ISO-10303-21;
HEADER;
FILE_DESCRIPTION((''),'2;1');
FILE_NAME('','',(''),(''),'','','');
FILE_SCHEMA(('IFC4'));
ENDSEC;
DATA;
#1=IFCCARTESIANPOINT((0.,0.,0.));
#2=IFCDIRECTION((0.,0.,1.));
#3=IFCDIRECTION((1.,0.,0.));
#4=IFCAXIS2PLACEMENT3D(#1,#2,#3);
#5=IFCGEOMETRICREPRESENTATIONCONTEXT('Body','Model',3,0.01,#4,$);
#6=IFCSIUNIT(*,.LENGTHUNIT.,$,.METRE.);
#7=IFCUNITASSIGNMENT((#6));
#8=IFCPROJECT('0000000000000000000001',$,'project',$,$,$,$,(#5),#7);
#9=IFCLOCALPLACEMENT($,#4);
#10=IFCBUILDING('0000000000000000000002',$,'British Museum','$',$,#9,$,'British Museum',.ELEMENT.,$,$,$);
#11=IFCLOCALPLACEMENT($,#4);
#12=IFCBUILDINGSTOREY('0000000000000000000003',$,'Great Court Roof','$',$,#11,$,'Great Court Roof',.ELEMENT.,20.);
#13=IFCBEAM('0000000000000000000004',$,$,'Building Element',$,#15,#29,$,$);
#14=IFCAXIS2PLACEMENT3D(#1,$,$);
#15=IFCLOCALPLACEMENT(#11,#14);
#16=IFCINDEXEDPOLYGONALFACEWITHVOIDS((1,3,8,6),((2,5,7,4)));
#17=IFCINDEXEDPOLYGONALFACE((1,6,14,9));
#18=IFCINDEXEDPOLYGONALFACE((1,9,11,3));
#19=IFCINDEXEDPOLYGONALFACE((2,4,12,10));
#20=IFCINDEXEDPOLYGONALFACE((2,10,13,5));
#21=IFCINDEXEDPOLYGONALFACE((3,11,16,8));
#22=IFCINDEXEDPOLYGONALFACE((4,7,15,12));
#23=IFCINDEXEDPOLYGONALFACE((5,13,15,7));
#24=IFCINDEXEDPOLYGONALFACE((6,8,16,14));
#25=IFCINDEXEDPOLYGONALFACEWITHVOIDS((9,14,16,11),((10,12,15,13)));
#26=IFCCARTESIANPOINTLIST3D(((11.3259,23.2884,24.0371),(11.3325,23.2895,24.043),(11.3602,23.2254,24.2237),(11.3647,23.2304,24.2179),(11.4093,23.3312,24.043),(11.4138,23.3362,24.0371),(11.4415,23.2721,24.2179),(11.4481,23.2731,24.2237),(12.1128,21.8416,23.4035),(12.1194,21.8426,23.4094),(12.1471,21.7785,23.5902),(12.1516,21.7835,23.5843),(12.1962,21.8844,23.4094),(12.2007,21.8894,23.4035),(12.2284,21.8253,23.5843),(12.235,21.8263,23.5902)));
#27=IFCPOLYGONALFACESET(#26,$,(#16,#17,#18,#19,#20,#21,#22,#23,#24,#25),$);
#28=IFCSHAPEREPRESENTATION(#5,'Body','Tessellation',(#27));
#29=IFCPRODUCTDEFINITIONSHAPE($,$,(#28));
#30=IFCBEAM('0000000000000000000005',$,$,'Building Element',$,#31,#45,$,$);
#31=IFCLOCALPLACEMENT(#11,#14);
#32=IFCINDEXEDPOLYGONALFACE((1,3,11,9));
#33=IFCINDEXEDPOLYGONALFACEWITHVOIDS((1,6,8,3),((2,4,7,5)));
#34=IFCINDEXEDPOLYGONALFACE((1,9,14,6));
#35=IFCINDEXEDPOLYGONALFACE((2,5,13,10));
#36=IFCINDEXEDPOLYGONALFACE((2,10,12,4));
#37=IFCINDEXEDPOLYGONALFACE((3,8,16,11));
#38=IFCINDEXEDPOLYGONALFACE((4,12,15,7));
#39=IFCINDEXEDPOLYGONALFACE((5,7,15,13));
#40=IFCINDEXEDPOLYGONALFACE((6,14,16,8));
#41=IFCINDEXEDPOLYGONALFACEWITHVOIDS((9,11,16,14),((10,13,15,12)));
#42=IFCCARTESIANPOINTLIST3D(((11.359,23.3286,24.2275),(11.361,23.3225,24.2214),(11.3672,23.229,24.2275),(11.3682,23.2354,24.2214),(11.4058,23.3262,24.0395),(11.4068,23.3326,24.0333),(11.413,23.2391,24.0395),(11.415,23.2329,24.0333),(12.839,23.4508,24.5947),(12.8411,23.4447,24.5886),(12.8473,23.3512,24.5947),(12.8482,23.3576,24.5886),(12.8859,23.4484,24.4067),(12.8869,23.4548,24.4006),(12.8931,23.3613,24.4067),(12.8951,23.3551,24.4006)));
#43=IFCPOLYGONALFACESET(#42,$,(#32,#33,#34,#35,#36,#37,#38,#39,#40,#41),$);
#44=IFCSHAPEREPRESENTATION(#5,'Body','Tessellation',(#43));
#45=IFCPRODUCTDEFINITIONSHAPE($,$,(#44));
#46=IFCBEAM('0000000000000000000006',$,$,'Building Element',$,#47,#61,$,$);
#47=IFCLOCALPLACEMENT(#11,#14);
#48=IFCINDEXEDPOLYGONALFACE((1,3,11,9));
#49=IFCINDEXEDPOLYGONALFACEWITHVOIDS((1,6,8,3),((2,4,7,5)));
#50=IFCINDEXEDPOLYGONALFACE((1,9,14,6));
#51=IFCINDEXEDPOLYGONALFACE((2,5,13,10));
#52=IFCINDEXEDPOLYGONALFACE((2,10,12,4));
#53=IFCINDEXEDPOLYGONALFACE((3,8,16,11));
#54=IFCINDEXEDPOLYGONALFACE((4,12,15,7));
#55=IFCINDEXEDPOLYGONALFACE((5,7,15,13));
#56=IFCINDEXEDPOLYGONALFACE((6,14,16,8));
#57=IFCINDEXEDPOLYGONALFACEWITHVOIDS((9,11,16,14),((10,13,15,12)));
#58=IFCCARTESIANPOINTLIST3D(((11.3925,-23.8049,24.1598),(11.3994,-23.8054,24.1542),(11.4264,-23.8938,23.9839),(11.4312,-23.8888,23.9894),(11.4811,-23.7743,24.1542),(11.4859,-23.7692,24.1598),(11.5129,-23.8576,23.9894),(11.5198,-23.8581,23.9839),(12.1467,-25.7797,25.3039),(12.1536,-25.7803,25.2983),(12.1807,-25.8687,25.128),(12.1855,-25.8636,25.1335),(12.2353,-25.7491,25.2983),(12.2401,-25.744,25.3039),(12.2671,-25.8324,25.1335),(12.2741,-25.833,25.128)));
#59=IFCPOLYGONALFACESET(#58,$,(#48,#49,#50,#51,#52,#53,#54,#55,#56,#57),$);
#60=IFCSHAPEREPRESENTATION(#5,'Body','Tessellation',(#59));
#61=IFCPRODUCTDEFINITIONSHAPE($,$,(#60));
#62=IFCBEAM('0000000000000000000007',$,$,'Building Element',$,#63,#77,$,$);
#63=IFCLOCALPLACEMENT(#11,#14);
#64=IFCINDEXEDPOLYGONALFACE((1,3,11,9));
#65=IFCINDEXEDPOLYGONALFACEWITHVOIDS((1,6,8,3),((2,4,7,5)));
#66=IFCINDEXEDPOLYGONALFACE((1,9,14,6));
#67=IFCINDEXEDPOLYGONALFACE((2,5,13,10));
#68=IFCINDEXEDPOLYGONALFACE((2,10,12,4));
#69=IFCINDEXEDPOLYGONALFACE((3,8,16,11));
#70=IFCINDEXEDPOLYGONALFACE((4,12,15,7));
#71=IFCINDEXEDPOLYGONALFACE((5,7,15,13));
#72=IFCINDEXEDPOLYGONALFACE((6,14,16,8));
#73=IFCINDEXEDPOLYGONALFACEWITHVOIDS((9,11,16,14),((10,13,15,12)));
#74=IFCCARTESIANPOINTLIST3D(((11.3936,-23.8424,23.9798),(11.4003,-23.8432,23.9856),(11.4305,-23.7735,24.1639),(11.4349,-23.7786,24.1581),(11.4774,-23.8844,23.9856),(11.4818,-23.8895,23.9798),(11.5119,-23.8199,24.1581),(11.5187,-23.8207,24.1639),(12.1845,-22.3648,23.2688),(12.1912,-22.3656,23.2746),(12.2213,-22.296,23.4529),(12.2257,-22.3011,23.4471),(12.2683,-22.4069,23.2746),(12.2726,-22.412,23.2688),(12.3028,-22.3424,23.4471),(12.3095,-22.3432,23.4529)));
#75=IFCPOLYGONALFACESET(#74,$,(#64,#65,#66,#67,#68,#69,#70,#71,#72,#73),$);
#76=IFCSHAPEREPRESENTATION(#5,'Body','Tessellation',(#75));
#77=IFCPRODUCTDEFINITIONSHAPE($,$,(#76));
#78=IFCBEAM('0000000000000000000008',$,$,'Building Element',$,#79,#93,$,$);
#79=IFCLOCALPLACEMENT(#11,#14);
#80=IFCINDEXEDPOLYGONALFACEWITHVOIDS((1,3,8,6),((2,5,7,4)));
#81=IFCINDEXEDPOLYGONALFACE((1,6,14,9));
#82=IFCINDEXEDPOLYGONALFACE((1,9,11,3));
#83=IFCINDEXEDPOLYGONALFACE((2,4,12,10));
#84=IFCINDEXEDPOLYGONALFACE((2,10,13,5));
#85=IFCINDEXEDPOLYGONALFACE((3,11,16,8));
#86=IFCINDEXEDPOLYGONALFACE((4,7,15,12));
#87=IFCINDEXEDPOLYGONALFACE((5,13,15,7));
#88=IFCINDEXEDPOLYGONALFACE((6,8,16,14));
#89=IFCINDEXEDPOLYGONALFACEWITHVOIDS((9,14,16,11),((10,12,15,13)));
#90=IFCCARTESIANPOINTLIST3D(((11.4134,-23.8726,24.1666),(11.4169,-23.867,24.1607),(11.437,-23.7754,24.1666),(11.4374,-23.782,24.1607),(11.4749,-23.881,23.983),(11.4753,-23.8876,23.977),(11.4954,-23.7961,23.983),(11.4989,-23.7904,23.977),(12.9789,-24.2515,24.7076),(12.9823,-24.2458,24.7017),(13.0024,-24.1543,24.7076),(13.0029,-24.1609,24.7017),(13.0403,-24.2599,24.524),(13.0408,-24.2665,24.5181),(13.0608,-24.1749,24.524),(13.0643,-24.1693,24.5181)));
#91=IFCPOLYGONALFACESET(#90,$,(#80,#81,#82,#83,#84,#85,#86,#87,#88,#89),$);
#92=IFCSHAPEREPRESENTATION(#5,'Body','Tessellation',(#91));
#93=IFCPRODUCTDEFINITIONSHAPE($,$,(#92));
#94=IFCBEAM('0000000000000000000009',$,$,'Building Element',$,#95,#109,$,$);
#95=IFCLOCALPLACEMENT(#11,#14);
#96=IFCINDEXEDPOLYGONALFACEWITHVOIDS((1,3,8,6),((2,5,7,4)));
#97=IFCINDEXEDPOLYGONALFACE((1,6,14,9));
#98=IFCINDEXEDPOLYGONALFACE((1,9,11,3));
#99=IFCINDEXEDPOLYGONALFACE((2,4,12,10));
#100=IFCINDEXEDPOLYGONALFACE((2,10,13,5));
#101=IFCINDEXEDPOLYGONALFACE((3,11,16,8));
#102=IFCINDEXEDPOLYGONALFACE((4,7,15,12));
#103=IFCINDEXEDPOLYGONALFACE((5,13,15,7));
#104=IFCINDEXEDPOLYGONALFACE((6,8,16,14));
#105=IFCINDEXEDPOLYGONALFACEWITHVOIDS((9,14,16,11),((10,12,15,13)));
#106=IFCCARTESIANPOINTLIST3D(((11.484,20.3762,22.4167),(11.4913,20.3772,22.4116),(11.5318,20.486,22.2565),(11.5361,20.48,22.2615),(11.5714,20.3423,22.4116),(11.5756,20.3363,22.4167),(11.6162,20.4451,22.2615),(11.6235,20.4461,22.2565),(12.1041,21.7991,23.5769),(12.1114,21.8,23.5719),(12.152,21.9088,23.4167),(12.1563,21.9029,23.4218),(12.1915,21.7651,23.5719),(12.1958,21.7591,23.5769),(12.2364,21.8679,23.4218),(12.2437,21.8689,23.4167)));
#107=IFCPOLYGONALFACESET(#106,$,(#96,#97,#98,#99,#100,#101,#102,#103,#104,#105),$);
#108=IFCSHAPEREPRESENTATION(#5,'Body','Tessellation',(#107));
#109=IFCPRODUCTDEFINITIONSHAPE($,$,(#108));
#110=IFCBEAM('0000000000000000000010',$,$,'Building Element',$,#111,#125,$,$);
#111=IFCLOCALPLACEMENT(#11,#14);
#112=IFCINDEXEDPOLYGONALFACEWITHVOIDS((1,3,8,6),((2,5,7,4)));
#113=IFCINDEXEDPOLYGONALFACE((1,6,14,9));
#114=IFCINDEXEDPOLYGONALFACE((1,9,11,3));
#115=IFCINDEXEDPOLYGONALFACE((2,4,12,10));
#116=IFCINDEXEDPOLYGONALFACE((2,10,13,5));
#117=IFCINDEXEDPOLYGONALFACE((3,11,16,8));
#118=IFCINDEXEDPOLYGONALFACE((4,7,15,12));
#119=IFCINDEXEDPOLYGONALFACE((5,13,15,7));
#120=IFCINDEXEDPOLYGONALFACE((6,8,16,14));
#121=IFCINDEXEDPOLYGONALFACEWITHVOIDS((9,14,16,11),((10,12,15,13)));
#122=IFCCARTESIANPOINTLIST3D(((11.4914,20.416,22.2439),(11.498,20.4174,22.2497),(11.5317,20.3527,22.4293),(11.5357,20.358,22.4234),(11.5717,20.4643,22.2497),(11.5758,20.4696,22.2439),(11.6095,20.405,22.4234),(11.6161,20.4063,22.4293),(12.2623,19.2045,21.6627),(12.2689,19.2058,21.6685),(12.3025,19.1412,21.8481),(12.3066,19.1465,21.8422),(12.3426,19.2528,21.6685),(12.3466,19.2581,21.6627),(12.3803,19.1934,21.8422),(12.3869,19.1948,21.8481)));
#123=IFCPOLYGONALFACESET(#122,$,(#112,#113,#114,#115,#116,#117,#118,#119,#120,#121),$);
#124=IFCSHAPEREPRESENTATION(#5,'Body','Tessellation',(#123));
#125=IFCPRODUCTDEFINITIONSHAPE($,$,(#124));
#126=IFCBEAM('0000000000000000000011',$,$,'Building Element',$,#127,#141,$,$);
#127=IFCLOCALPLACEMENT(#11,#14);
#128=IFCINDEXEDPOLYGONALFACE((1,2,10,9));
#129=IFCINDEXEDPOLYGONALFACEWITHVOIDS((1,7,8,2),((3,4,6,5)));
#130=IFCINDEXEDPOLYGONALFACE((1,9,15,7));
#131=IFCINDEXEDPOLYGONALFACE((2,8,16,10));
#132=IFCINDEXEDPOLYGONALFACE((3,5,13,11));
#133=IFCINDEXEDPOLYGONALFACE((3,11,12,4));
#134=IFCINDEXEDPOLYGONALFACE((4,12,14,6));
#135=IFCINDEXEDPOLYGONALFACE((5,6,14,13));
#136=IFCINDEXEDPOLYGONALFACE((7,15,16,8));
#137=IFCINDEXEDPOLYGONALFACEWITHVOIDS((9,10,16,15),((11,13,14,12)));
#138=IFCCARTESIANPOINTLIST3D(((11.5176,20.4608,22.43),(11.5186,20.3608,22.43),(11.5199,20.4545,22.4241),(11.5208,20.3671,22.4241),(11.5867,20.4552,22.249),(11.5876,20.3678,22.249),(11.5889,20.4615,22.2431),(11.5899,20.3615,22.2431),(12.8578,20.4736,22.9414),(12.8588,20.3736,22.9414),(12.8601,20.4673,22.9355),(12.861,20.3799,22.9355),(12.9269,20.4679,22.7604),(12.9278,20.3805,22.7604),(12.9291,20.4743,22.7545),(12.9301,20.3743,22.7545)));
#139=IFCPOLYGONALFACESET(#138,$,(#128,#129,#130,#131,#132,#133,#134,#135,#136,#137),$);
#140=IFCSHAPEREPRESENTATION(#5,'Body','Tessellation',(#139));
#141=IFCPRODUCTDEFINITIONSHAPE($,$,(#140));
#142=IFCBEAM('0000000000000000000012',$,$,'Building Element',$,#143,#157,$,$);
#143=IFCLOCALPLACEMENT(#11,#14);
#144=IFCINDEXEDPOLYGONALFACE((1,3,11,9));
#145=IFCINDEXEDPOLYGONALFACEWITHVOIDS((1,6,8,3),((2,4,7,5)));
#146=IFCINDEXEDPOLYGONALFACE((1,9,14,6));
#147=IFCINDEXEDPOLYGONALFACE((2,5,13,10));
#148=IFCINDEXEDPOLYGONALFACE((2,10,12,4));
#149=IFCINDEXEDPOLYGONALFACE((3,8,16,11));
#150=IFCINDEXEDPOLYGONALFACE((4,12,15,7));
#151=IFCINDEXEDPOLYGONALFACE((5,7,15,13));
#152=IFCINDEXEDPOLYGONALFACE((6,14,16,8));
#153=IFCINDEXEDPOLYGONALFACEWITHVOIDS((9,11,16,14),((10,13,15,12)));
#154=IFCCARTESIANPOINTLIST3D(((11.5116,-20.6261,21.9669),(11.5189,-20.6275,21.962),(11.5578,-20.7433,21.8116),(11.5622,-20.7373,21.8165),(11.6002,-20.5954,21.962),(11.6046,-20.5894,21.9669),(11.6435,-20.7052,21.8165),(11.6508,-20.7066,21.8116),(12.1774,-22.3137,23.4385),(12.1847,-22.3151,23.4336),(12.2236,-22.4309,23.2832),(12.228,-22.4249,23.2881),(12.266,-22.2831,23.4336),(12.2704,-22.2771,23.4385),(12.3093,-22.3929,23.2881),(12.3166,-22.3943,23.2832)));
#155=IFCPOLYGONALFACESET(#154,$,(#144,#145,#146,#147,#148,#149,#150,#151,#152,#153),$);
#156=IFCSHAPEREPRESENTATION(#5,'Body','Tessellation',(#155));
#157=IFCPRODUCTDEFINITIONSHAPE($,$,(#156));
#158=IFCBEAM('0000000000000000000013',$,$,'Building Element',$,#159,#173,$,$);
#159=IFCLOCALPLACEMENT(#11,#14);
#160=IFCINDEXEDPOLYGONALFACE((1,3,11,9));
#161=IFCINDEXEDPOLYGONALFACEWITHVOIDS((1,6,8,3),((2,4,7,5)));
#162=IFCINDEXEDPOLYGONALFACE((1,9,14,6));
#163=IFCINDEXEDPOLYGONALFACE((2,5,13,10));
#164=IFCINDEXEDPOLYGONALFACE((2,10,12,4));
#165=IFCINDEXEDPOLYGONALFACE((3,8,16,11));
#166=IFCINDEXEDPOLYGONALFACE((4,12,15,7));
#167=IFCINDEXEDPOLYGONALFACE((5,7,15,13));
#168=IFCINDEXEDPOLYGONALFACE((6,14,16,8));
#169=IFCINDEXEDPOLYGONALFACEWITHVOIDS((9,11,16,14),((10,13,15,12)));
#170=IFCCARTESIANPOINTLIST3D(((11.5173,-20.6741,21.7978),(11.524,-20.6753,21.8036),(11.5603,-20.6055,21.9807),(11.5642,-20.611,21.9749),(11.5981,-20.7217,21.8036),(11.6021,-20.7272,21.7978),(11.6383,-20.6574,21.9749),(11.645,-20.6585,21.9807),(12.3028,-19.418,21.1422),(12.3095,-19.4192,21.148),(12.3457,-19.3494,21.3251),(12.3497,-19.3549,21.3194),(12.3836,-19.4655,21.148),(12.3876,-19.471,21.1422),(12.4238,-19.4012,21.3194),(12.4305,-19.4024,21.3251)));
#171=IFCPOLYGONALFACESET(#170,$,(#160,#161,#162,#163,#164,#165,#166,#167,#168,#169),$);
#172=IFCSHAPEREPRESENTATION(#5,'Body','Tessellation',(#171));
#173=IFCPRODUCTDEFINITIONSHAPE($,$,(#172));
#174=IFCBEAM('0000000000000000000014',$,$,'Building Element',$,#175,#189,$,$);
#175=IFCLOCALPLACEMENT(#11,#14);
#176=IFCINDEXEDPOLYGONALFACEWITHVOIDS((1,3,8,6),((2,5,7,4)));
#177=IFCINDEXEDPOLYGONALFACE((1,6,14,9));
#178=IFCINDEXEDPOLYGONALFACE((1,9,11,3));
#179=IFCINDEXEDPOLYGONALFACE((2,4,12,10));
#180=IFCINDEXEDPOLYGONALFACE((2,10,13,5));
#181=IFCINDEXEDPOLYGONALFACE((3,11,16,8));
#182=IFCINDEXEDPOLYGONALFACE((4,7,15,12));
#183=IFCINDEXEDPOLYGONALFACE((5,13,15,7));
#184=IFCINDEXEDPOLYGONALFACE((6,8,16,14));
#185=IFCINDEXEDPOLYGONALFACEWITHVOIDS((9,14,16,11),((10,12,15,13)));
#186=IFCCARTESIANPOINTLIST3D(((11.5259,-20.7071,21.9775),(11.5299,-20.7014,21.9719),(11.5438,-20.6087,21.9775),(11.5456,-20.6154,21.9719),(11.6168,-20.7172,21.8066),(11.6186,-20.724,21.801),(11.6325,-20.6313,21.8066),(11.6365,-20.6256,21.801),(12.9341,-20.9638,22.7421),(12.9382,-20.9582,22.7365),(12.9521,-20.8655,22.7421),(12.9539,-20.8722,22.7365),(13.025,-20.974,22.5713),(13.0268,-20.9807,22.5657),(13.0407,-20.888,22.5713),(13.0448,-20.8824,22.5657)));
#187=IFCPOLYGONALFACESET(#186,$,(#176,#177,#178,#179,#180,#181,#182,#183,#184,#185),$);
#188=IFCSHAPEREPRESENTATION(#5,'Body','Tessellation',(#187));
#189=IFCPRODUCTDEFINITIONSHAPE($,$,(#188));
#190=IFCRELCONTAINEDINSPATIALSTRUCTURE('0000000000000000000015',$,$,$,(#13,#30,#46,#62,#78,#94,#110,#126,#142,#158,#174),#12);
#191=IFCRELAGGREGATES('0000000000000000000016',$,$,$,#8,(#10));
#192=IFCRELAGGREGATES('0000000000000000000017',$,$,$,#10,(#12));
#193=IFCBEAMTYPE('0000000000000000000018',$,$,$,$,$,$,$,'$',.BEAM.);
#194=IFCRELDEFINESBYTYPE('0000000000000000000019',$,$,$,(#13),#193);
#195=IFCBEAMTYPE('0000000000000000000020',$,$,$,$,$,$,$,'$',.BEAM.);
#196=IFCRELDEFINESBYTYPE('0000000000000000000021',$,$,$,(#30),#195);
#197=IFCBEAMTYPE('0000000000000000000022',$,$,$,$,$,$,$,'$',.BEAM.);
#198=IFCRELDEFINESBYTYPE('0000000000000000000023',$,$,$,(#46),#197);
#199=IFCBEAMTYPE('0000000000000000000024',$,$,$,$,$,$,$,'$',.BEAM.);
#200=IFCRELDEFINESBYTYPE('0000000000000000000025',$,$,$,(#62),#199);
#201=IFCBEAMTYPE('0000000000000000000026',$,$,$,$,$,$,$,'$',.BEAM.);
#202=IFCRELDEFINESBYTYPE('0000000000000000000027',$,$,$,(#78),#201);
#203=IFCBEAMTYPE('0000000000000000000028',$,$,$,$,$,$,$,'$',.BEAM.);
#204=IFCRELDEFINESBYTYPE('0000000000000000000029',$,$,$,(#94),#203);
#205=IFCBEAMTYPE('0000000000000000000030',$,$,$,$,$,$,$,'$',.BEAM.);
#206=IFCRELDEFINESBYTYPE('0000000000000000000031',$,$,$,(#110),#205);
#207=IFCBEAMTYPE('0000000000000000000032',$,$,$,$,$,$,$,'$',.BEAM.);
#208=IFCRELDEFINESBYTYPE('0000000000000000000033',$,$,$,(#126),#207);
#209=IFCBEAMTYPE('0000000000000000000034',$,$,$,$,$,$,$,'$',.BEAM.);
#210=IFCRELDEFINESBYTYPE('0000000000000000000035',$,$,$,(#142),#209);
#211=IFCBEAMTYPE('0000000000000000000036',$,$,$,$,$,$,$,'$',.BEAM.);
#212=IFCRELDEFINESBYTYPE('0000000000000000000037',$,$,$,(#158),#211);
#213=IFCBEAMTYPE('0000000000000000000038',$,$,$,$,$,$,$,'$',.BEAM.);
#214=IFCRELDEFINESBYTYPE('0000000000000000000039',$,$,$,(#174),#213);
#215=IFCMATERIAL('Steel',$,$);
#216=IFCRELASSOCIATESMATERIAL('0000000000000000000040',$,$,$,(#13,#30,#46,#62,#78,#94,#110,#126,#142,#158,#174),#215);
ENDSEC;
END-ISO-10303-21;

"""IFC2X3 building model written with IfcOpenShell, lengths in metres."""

from ifc_helpers import new_model, si_unit, frame, origin_with_axes, origin_2d, place, context, project, spatial, hollow_rectangle, extrude, material, type_object, element, save


model = new_model("IFC2X3")

# Units and contexts
model_context = context("Model", 3, precision=0.01, world=origin_with_axes(), identifier="Body")
ifc_project = project(units=[si_unit("LENGTHUNIT", "METRE")], contexts=[model_context])

# Building, storey
building_placement = place(None, origin_with_axes())
building = spatial("IfcBuilding", under=ifc_project, at=building_placement, Name="British Museum", Description="$", LongName="British Museum", CompositionType="ELEMENT")
storey_placement = place(None, origin_with_axes())
storey = spatial("IfcBuildingStorey", under=building, at=storey_placement, Name="Great Court Roof", Description="$", LongName="Great Court Roof", CompositionType="ELEMENT", Elevation=20.0)

# Beams
ifc_material = material(Name="Steel")
beam_type_1 = type_object("IfcBeamType", ElementType="$", PredefinedType="BEAM")
beam_1_placement = place(None, origin_with_axes())
element("IfcBeam", 1, at=beam_1_placement, inside=storey, type_object=beam_type_1, material=ifc_material, Description="Building Element", context=model_context, shape_type="SweptSolid", body=[
    extrude(hollow_rectangle(XDim=0.1, YDim=0.2, WallThickness=0.0063, InnerFilletRadius=-0.0063, OuterFilletRadius=0.0, at=origin_2d()), frame((11.387, 23.2808, 24.1304), z_axis=(0.445928, -0.819903, -0.359038), x_axis=(0.878477, 0.477785, 0.0)), (0.0, 0.0, 1.0), 1.7646),
])
beam_type_2 = type_object("IfcBeamType", ElementType="$", PredefinedType="BEAM")
beam_2_placement = place(None, origin_with_axes())
element("IfcBeam", 2, at=beam_2_placement, inside=storey, type_object=beam_type_2, material=ifc_material, Description="Building Element", context=model_context, shape_type="SweptSolid", body=[
    extrude(hollow_rectangle(XDim=0.1, YDim=0.2, WallThickness=0.0063, InnerFilletRadius=-0.0063, OuterFilletRadius=0.0, at=origin_2d()), frame((11.387, 23.2808, 24.1304), z_axis=(0.967466, 0.07987, 0.240061), x_axis=(-0.082276, 0.99661, 0.0)), (0.0, 0.0, 1.0), 1.5298),
])
beam_type_3 = type_object("IfcBeamType", ElementType="$", PredefinedType="BEAM")
beam_3_placement = place(None, origin_with_axes())
element("IfcBeam", 3, at=beam_3_placement, inside=storey, type_object=beam_type_3, material=ifc_material, Description="Building Element", context=model_context, shape_type="SweptSolid", body=[
    extrude(hollow_rectangle(XDim=0.1, YDim=0.2, WallThickness=0.0063, InnerFilletRadius=-0.0063, OuterFilletRadius=0.0, at=origin_2d()), frame((11.4561, -23.8315, 24.0718), z_axis=(0.31378, -0.821581, 0.47597), x_axis=(0.934186, 0.356787, 0.0)), (0.0, 0.0, 1.0), 2.4037),
])
beam_type_4 = type_object("IfcBeamType", ElementType="$", PredefinedType="BEAM")
beam_4_placement = place(None, origin_with_axes())
element("IfcBeam", 4, at=beam_4_placement, inside=storey, type_object=beam_type_4, material=ifc_material, Description="Building Element", context=model_context, shape_type="SweptSolid", body=[
    extrude(hollow_rectangle(XDim=0.1, YDim=0.2, WallThickness=0.0063, InnerFilletRadius=-0.0063, OuterFilletRadius=0.0, at=origin_2d()), frame((11.4561, -23.8315, 24.0718), z_axis=(0.43443, 0.811623, -0.390562), x_axis=(-0.881646, 0.471911, 0.0)), (0.0, 0.0, 1.0), 1.8204),
])
beam_type_5 = type_object("IfcBeamType", ElementType="$", PredefinedType="BEAM")
beam_5_placement = place(None, origin_with_axes())
element("IfcBeam", 5, at=beam_5_placement, inside=storey, type_object=beam_type_5, material=ifc_material, Description="Building Element", context=model_context, shape_type="SweptSolid", body=[
    extrude(hollow_rectangle(XDim=0.1, YDim=0.2, WallThickness=0.0063, InnerFilletRadius=-0.0063, OuterFilletRadius=0.0, at=origin_2d()), frame((11.4561, -23.8315, 24.0718), z_axis=(0.921349, -0.222991, 0.318418), x_axis=(0.235235, 0.971938, 0.0)), (0.0, 0.0, 1.0), 1.6991),
])
beam_type_6 = type_object("IfcBeamType", ElementType="$", PredefinedType="BEAM")
beam_6_placement = place(None, origin_with_axes())
element("IfcBeam", 6, at=beam_6_placement, inside=storey, type_object=beam_type_6, material=ifc_material, Description="Building Element", context=model_context, shape_type="SweptSolid", body=[
    extrude(hollow_rectangle(XDim=0.1, YDim=0.2, WallThickness=0.0063, InnerFilletRadius=-0.0063, OuterFilletRadius=0.0, at=origin_2d()), frame((11.5537, 20.4112, 22.3366), z_axis=(0.320027, 0.734228, 0.598742), x_axis=(-0.916706, 0.399563, 0.0)), (0.0, 0.0, 1.0), 1.9378),
])
beam_type_7 = type_object("IfcBeamType", ElementType="$", PredefinedType="BEAM")
beam_7_placement = place(None, origin_with_axes())
element("IfcBeam", 7, at=beam_7_placement, inside=storey, type_object=beam_type_7, material=ifc_material, Description="Building Element", context=model_context, shape_type="SweptSolid", body=[
    extrude(hollow_rectangle(XDim=0.1, YDim=0.2, WallThickness=0.0063, InnerFilletRadius=-0.0063, OuterFilletRadius=0.0, at=origin_2d()), frame((11.5537, 20.4112, 22.3366), z_axis=(0.497612, -0.782064, -0.375178), x_axis=(0.843693, 0.536825, 0.0)), (0.0, 0.0, 1.0), 1.5491),
])
beam_type_8 = type_object("IfcBeamType", ElementType="$", PredefinedType="BEAM")
beam_8_placement = place(None, origin_with_axes())
element("IfcBeam", 8, at=beam_8_placement, inside=storey, type_object=beam_type_8, material=ifc_material, Description="Building Element", context=model_context, shape_type="SweptSolid", body=[
    extrude(hollow_rectangle(XDim=0.1, YDim=0.2, WallThickness=0.0063, InnerFilletRadius=-0.0063, OuterFilletRadius=0.0, at=origin_2d()), frame((11.5537, 20.4112, 22.3366), z_axis=(0.934258, 0.008904, 0.356487), x_axis=(-0.00953, 0.999955, 0.0)), (0.0, 0.0, 1.0), 1.4345),
])
beam_type_9 = type_object("IfcBeamType", ElementType="$", PredefinedType="BEAM")
beam_9_placement = place(None, origin_with_axes())
element("IfcBeam", 9, at=beam_9_placement, inside=storey, type_object=beam_type_9, material=ifc_material, Description="Building Element", context=model_context, shape_type="SweptSolid", body=[
    extrude(hollow_rectangle(XDim=0.1, YDim=0.2, WallThickness=0.0063, InnerFilletRadius=-0.0063, OuterFilletRadius=0.0, at=origin_2d()), frame((11.5812, -20.6663, 21.8893), z_axis=(0.285014, -0.722445, 0.629952), x_axis=(0.930226, 0.366987, 0.0)), (0.0, 0.0, 1.0), 2.336),
])
beam_type_10 = type_object("IfcBeamType", ElementType="$", PredefinedType="BEAM")
beam_10_placement = place(None, origin_with_axes())
element("IfcBeam", 10, at=beam_10_placement, inside=storey, type_object=beam_type_10, material=ifc_material, Description="Building Element", context=model_context, shape_type="SweptSolid", body=[
    extrude(hollow_rectangle(XDim=0.1, YDim=0.2, WallThickness=0.0063, InnerFilletRadius=-0.0063, OuterFilletRadius=0.0, at=origin_2d()), frame((11.5812, -20.6663, 21.8893), z_axis=(0.484821, 0.775363, -0.404674), x_axis=(-0.84789, 0.530172, 0.0)), (0.0, 0.0, 1.0), 1.62),
])
beam_type_11 = type_object("IfcBeamType", ElementType="$", PredefinedType="BEAM")
beam_11_placement = place(None, origin_with_axes())
element("IfcBeam", 11, at=beam_11_placement, inside=storey, type_object=beam_type_11, material=ifc_material, Description="Building Element", context=model_context, shape_type="SweptSolid", body=[
    extrude(hollow_rectangle(XDim=0.1, YDim=0.2, WallThickness=0.0063, InnerFilletRadius=-0.0063, OuterFilletRadius=0.0, at=origin_2d()), frame((11.5812, -20.6663, 21.8893), z_axis=(0.867741, -0.158211, 0.471163), x_axis=(0.179368, 0.983782, 0.0)), (0.0, 0.0, 1.0), 1.6229),
])

save(model, "model.ifc")
